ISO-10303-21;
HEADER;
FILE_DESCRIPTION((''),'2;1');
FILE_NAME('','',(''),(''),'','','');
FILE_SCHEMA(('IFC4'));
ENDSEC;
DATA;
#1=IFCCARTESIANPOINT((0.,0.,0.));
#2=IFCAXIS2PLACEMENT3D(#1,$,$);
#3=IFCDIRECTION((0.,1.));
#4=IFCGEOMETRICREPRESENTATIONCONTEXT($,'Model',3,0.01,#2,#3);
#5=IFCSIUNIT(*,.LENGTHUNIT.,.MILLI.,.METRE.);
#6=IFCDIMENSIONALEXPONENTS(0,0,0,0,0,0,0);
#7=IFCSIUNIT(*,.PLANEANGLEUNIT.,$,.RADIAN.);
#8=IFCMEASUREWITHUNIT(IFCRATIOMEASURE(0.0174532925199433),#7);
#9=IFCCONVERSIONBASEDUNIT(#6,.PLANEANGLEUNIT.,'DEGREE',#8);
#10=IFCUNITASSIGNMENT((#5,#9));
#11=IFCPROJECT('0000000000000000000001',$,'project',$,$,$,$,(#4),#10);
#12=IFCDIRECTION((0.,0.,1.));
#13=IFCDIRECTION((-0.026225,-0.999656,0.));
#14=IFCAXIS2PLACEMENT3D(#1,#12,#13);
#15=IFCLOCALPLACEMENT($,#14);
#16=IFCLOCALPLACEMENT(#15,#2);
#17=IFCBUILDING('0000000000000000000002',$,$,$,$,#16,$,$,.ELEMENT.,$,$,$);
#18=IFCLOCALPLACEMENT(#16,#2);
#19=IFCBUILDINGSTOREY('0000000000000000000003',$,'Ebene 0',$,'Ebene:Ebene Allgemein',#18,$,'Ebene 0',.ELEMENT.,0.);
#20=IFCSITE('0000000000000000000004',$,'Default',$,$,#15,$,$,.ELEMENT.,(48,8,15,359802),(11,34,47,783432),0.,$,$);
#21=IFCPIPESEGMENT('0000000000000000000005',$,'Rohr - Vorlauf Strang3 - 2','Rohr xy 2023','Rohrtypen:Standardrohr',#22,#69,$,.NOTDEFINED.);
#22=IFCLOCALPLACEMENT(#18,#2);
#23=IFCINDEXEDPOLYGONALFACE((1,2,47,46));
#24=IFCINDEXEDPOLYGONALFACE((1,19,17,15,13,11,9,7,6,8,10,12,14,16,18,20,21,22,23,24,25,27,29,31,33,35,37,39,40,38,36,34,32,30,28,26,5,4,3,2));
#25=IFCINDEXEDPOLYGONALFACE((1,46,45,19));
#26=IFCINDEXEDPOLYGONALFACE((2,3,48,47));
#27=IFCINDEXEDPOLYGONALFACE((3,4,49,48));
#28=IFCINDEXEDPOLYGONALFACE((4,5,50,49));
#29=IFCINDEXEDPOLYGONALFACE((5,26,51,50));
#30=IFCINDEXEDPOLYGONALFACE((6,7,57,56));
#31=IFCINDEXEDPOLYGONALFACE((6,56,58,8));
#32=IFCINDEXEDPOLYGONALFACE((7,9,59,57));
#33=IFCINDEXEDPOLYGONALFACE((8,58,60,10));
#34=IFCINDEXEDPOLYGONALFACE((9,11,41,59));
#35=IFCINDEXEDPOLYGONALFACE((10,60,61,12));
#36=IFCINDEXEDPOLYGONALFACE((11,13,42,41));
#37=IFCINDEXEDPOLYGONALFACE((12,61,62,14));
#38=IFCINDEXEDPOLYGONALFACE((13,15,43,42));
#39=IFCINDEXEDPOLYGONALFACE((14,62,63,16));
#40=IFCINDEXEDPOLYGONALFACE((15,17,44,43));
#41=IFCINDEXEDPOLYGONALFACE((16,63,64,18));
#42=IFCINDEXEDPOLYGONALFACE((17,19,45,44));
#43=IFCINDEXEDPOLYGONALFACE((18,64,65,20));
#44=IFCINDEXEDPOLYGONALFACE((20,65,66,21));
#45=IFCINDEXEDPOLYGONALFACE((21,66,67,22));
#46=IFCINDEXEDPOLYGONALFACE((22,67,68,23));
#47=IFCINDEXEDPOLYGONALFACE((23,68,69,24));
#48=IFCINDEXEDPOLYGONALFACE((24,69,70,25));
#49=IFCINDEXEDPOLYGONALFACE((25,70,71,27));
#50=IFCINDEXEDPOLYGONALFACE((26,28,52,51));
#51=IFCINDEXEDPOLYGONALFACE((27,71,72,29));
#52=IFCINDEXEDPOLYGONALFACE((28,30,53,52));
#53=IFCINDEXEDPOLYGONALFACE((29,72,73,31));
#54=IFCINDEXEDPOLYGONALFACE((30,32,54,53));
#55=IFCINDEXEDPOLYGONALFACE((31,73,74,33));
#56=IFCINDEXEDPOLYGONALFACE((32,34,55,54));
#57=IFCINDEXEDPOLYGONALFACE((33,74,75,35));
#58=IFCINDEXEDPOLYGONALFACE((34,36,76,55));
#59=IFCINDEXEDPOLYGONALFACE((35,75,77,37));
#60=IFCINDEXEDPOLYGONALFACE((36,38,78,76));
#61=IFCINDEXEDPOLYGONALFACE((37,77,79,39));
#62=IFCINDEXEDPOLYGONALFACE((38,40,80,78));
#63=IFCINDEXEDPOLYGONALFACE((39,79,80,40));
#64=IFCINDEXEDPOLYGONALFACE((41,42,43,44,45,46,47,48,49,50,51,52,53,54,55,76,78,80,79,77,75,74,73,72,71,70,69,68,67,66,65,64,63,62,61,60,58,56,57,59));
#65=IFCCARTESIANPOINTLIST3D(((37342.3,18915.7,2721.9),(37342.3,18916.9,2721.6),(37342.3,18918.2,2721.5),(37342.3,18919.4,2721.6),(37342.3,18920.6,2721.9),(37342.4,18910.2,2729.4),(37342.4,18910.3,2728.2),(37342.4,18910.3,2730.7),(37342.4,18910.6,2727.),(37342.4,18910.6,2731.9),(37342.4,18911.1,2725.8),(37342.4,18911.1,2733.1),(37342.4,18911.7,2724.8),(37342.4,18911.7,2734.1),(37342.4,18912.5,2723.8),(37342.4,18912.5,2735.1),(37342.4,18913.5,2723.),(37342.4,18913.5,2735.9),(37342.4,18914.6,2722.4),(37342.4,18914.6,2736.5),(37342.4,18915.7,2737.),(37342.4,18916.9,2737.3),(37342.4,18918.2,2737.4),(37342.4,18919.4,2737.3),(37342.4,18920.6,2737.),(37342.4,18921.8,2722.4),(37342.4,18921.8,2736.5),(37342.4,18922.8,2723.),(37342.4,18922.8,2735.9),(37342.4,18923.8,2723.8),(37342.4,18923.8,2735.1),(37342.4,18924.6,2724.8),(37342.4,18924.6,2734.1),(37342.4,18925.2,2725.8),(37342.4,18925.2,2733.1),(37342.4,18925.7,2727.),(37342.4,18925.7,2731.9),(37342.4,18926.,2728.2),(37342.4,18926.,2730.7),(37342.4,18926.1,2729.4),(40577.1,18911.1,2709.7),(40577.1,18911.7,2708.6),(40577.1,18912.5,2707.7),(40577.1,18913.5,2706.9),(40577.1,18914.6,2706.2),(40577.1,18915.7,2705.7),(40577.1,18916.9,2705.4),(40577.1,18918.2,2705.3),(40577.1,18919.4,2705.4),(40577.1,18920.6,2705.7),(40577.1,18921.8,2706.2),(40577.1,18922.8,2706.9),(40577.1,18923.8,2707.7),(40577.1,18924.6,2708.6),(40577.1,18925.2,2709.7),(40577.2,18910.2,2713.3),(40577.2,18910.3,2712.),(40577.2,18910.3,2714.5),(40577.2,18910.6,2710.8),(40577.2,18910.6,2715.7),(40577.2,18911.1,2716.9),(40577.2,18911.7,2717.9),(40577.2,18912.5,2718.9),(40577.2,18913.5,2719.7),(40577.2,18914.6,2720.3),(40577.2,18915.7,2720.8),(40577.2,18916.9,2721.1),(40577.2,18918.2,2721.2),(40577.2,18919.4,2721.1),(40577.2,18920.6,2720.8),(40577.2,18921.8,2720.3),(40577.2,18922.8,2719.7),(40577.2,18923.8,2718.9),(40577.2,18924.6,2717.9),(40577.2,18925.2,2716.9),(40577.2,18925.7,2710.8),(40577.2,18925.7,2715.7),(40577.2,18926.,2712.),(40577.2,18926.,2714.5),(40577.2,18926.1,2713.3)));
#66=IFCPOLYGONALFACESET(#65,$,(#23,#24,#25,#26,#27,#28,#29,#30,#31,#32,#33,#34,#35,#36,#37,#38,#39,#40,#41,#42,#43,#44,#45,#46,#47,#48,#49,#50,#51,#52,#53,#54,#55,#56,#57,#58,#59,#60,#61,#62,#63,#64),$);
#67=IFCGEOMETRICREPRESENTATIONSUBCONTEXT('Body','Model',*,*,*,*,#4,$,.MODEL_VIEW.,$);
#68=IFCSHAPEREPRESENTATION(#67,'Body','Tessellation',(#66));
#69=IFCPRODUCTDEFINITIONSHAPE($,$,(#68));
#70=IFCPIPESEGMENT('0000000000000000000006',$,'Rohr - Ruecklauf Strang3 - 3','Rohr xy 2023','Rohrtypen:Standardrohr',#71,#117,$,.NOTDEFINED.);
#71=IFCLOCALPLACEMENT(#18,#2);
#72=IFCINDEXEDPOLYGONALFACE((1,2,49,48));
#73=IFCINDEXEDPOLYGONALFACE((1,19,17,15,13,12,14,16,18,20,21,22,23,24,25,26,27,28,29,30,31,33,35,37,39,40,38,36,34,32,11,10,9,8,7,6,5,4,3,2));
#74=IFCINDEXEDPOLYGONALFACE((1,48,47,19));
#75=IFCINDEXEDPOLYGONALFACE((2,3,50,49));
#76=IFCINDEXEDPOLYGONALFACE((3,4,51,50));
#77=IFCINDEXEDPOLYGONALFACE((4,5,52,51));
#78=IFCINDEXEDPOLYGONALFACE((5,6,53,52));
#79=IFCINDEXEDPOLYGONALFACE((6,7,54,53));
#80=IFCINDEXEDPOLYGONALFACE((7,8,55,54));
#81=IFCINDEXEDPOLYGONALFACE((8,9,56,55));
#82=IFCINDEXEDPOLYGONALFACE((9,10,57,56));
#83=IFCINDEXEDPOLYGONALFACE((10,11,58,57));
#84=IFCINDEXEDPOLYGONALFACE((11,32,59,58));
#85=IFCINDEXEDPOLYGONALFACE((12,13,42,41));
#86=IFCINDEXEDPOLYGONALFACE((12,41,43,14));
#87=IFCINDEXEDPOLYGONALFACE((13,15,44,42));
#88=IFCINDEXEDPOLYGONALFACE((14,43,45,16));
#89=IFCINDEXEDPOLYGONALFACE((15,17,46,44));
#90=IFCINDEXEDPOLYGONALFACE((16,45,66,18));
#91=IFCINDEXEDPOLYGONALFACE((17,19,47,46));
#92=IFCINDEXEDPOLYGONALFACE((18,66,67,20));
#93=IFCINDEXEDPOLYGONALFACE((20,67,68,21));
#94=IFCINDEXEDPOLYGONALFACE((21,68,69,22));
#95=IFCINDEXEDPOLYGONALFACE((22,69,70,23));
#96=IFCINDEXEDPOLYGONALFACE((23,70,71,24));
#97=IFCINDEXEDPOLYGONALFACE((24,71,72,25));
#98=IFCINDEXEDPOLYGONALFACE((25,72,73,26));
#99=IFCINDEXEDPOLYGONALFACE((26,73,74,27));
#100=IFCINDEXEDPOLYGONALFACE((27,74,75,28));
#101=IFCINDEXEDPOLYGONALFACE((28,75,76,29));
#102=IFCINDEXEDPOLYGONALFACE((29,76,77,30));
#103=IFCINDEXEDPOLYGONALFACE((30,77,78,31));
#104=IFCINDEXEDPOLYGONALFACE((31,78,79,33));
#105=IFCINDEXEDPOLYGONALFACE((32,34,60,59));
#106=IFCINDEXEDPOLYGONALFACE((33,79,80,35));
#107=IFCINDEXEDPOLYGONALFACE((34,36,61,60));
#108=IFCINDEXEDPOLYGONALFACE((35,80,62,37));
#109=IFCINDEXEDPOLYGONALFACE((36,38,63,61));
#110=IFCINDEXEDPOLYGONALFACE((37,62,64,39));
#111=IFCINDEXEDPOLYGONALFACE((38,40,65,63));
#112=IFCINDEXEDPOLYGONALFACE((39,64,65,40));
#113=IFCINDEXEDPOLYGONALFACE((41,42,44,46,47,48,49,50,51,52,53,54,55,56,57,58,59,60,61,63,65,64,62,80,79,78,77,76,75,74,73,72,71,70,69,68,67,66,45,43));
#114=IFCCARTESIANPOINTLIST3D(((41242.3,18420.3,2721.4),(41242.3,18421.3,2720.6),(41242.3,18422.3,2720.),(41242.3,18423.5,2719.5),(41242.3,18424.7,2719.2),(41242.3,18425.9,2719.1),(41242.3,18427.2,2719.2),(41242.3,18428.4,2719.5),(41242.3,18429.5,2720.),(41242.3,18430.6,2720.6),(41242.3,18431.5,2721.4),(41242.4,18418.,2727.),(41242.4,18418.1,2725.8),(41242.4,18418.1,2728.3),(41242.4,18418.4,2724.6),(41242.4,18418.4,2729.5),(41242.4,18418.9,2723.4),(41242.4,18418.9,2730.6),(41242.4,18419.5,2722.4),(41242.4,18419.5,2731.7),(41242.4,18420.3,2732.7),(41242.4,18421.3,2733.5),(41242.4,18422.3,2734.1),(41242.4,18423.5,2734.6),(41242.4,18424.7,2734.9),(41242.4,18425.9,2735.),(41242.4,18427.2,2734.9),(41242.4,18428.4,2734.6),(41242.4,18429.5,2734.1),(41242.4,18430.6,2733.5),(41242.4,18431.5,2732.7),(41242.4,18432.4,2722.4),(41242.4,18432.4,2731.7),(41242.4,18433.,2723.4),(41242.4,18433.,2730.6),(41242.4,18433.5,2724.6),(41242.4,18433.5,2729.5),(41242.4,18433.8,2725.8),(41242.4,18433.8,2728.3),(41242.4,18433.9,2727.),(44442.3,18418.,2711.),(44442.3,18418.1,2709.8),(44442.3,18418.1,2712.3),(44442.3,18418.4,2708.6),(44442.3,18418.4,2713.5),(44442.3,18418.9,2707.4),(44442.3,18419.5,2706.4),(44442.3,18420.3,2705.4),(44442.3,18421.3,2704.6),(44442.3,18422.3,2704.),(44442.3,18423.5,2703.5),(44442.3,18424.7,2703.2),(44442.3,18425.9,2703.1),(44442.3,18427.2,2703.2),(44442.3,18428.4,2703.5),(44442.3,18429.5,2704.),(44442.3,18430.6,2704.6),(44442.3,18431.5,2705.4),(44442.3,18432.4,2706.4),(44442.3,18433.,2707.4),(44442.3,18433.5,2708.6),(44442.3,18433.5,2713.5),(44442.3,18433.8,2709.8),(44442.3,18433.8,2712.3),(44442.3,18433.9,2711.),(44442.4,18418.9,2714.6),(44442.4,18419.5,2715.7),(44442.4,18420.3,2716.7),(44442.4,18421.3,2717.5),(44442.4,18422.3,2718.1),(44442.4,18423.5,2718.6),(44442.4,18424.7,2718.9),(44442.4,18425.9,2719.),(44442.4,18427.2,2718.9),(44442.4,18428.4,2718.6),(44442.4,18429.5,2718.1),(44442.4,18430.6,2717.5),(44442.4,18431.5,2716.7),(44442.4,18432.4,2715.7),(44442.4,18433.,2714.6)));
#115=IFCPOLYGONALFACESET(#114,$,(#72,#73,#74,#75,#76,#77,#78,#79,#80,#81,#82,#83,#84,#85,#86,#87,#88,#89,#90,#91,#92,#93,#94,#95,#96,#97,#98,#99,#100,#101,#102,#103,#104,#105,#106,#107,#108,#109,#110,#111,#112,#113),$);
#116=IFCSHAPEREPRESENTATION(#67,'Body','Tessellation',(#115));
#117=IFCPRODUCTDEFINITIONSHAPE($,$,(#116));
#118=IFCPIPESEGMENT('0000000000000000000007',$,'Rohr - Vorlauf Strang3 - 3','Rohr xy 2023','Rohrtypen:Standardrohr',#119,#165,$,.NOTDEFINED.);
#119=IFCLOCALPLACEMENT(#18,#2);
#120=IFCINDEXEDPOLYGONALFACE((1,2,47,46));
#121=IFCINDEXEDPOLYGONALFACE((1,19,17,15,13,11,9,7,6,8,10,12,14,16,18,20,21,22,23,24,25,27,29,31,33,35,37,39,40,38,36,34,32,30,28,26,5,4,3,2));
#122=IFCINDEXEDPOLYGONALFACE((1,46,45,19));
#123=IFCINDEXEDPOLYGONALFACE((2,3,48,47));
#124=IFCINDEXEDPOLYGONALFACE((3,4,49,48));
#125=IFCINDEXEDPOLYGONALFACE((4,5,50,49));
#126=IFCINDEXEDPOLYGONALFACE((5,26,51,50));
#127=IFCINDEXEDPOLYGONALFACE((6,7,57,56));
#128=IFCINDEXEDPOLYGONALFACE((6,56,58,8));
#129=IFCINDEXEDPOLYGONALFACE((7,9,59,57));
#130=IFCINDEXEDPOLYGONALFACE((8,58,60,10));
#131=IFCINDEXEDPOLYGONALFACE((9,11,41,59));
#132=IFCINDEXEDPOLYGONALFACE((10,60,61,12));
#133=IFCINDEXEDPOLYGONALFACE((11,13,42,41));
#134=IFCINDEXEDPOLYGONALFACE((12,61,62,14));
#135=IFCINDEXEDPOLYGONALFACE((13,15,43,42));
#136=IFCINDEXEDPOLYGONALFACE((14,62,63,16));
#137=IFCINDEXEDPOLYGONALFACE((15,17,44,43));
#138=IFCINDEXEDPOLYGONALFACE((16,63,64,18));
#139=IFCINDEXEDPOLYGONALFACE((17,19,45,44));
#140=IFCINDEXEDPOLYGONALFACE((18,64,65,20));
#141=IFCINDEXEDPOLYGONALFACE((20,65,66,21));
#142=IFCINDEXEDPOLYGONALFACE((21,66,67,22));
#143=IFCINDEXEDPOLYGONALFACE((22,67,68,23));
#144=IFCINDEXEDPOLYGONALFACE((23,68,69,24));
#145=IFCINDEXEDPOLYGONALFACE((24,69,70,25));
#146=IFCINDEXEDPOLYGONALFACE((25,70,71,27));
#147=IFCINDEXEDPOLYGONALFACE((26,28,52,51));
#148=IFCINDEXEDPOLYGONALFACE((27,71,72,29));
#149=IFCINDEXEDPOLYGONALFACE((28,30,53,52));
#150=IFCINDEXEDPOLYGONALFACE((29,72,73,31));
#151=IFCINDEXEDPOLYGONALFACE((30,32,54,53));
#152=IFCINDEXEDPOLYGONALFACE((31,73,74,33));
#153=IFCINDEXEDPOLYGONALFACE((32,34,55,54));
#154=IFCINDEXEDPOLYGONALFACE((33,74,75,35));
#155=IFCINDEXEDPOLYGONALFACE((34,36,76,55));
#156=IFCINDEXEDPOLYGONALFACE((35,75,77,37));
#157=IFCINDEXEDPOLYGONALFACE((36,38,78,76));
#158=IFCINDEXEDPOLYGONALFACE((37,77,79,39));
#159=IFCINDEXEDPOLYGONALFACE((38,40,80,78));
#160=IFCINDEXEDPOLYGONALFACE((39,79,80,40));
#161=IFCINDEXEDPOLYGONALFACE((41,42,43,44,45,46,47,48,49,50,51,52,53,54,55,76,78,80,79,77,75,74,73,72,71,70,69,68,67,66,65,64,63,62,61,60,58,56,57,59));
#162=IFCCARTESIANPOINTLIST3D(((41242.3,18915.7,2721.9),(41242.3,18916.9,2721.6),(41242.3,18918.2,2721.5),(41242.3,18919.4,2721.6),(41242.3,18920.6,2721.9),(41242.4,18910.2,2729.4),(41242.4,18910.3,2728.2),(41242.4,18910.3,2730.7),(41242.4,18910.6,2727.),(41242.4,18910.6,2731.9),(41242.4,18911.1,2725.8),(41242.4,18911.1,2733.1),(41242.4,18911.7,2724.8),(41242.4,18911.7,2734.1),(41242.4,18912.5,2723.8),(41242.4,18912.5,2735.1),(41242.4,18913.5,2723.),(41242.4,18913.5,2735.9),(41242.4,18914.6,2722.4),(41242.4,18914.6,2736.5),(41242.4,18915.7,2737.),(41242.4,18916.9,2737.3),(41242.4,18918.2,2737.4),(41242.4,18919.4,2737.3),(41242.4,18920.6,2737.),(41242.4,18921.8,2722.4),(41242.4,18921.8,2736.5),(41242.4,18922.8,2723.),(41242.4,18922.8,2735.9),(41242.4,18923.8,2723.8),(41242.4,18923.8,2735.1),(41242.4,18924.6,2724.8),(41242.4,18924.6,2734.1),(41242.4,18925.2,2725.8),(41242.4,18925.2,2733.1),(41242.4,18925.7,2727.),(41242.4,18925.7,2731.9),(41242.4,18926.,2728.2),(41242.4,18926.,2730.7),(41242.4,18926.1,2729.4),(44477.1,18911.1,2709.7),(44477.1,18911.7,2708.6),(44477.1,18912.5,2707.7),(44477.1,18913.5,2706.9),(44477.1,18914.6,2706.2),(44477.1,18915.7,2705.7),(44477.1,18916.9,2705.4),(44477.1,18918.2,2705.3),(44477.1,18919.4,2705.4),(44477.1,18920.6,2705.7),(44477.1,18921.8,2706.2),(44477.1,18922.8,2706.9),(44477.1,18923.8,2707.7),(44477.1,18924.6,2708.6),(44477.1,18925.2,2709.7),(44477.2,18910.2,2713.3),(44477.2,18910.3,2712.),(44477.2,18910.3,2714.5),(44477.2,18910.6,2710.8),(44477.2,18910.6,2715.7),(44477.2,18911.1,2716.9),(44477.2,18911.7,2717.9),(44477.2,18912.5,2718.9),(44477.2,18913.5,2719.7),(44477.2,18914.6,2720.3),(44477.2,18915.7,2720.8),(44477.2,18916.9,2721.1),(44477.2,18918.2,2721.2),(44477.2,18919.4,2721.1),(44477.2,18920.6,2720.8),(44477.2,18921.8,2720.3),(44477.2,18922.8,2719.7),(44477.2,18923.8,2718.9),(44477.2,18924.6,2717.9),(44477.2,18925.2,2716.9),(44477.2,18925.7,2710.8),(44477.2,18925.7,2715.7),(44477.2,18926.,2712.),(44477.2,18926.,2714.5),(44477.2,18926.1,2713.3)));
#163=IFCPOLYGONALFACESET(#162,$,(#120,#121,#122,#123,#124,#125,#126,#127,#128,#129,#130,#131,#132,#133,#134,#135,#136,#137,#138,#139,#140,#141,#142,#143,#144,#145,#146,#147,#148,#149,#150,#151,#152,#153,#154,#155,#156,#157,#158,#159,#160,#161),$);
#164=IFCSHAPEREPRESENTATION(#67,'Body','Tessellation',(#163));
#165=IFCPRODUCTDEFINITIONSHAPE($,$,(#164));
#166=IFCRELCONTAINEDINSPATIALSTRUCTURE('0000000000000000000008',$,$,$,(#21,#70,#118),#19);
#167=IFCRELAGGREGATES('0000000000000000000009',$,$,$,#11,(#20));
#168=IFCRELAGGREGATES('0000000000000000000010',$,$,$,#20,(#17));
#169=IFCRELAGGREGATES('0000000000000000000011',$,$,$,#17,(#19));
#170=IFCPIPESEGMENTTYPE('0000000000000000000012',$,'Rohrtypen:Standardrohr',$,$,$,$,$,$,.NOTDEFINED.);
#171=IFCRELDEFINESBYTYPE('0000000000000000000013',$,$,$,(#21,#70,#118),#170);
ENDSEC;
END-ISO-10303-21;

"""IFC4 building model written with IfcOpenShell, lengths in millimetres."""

from ifc_helpers import new_model, entity, si_unit, converted_unit, direction, frame, origin, place, context, subcontext, project, spatial, indexed_curve, outline, extrude, type_object, element, save


model = new_model("IFC4")

# Units and contexts
model_context = context("Model", 3, precision=0.01, world=origin(), true_north=direction((0.0, 1.0)))
body_context = subcontext(model_context, "Body", "Model", "MODEL_VIEW")
ifc_project = project(units=[si_unit("LENGTHUNIT", "METRE", prefix="MILLI"), converted_unit("PLANEANGLEUNIT", "DEGREE", entity("IfcRatioMeasure", 0.0174532925199433), si_unit("PLANEANGLEUNIT", "RADIAN"), dimensions=[0, 0, 0, 0, 0, 0, 0])], contexts=[model_context])

# Site, building, storey
site_placement = place(None, frame((0.0, 0.0, 0.0), z_axis=(0.0, 0.0, 1.0), x_axis=(-0.026225, -0.999656, 0.0)))
site = spatial("IfcSite", under=ifc_project, at=site_placement, Name="Default", CompositionType="ELEMENT", RefLatitude=(48, 8, 15, 359802), RefLongitude=(11, 34, 47, 783432), RefElevation=0.0)
building_placement = place(site_placement, origin())
building = spatial("IfcBuilding", under=site, at=building_placement, CompositionType="ELEMENT")
storey_placement = place(building_placement, origin())
storey = spatial("IfcBuildingStorey", under=building, at=storey_placement, Name="Ebene 0", ObjectType="Ebene:Ebene Allgemein", LongName="Ebene 0", CompositionType="ELEMENT", Elevation=0.0)

# Pipe segments
pipe_segment_type = type_object("IfcPipeSegmentType", Name="Rohrtypen:Standardrohr", PredefinedType="NOTDEFINED")
pipe_segment_1_placement = place(storey_placement, origin())
element("IfcPipeSegment", 1, at=pipe_segment_1_placement, inside=storey, type_object=pipe_segment_type, Name="Rohr - Vorlauf Strang3 - 2", Description="Rohr xy 2023", ObjectType="Rohrtypen:Standardrohr", PredefinedType="NOTDEFINED", context=body_context, shape_type="SweptSolid", body=[
    extrude(outline(indexed_curve([(7.9, 0.0), (7.8, 1.2), (7.6, 2.5), (7.1, 3.6), (6.4, 4.7), (5.6, 5.6), (4.7, 6.4), (3.6, 7.1), (2.5, 7.6), (1.2, 7.8), (0.0, 7.9), (-1.2, 7.8), (-2.5, 7.6), (-3.6, 7.1), (-4.7, 6.4), (-5.6, 5.6), (-6.4, 4.7), (-7.1, 3.6), (-7.6, 2.5), (-7.8, 1.2), (-7.9, 0.0), (-7.8, -1.2), (-7.6, -2.5), (-7.1, -3.6), (-6.4, -4.7), (-5.6, -5.6), (-4.7, -6.4), (-3.6, -7.1), (-2.5, -7.6), (-1.2, -7.8), (0.0, -7.9), (1.2, -7.8), (2.5, -7.6), (3.6, -7.1), (4.7, -6.4), (5.6, -5.6), (6.4, -4.7), (7.1, -3.6), (7.6, -2.5), (7.8, -1.2), (7.9, 0.0)], self_intersect=False)), frame((40577.2, 18918.2, 2713.3), z_axis=(-0.999988, 0.0, 0.005), x_axis=(0.0, 1.0, 0.0)), (0.0, 0.0, 1.0), 3234.8),
])
pipe_segment_2_placement = place(storey_placement, origin())
element("IfcPipeSegment", 2, at=pipe_segment_2_placement, inside=storey, type_object=pipe_segment_type, Name="Rohr - Ruecklauf Strang3 - 3", Description="Rohr xy 2023", ObjectType="Rohrtypen:Standardrohr", PredefinedType="NOTDEFINED", context=body_context, shape_type="SweptSolid", body=[
    extrude(outline(indexed_curve([(7.9, 0.0), (7.8, 1.2), (7.6, 2.5), (7.1, 3.6), (6.4, 4.7), (5.6, 5.6), (4.7, 6.4), (3.6, 7.1), (2.5, 7.6), (1.2, 7.8), (0.0, 7.9), (-1.2, 7.8), (-2.5, 7.6), (-3.6, 7.1), (-4.7, 6.4), (-5.6, 5.6), (-6.4, 4.7), (-7.1, 3.6), (-7.6, 2.5), (-7.8, 1.2), (-7.9, 0.0), (-7.8, -1.2), (-7.6, -2.5), (-7.1, -3.6), (-6.4, -4.7), (-5.6, -5.6), (-4.7, -6.4), (-3.6, -7.1), (-2.5, -7.6), (-1.2, -7.8), (0.0, -7.9), (1.2, -7.8), (2.5, -7.6), (3.6, -7.1), (4.7, -6.4), (5.6, -5.6), (6.4, -4.7), (7.1, -3.6), (7.6, -2.5), (7.8, -1.2), (7.9, 0.0)], self_intersect=False)), frame((44442.3, 18425.9, 2711.0), z_axis=(-0.999988, 0.0, 0.005), x_axis=(0.0, 1.0, 0.0)), (0.0, 0.0, 1.0), 3200.0),
])
pipe_segment_3_placement = place(storey_placement, origin())
element("IfcPipeSegment", 3, at=pipe_segment_3_placement, inside=storey, type_object=pipe_segment_type, Name="Rohr - Vorlauf Strang3 - 3", Description="Rohr xy 2023", ObjectType="Rohrtypen:Standardrohr", PredefinedType="NOTDEFINED", context=body_context, shape_type="SweptSolid", body=[
    extrude(outline(indexed_curve([(7.9, 0.0), (7.8, 1.2), (7.6, 2.5), (7.1, 3.6), (6.4, 4.7), (5.6, 5.6), (4.7, 6.4), (3.6, 7.1), (2.5, 7.6), (1.2, 7.8), (0.0, 7.9), (-1.2, 7.8), (-2.5, 7.6), (-3.6, 7.1), (-4.7, 6.4), (-5.6, 5.6), (-6.4, 4.7), (-7.1, 3.6), (-7.6, 2.5), (-7.8, 1.2), (-7.9, 0.0), (-7.8, -1.2), (-7.6, -2.5), (-7.1, -3.6), (-6.4, -4.7), (-5.6, -5.6), (-4.7, -6.4), (-3.6, -7.1), (-2.5, -7.6), (-1.2, -7.8), (0.0, -7.9), (1.2, -7.8), (2.5, -7.6), (3.6, -7.1), (4.7, -6.4), (5.6, -5.6), (6.4, -4.7), (7.1, -3.6), (7.6, -2.5), (7.8, -1.2), (7.9, 0.0)], self_intersect=False)), frame((44477.2, 18918.2, 2713.3), z_axis=(-0.999988, 0.0, 0.005), x_axis=(0.0, 1.0, 0.0)), (0.0, 0.0, 1.0), 3234.8),
])

save(model, "model.ifc")
